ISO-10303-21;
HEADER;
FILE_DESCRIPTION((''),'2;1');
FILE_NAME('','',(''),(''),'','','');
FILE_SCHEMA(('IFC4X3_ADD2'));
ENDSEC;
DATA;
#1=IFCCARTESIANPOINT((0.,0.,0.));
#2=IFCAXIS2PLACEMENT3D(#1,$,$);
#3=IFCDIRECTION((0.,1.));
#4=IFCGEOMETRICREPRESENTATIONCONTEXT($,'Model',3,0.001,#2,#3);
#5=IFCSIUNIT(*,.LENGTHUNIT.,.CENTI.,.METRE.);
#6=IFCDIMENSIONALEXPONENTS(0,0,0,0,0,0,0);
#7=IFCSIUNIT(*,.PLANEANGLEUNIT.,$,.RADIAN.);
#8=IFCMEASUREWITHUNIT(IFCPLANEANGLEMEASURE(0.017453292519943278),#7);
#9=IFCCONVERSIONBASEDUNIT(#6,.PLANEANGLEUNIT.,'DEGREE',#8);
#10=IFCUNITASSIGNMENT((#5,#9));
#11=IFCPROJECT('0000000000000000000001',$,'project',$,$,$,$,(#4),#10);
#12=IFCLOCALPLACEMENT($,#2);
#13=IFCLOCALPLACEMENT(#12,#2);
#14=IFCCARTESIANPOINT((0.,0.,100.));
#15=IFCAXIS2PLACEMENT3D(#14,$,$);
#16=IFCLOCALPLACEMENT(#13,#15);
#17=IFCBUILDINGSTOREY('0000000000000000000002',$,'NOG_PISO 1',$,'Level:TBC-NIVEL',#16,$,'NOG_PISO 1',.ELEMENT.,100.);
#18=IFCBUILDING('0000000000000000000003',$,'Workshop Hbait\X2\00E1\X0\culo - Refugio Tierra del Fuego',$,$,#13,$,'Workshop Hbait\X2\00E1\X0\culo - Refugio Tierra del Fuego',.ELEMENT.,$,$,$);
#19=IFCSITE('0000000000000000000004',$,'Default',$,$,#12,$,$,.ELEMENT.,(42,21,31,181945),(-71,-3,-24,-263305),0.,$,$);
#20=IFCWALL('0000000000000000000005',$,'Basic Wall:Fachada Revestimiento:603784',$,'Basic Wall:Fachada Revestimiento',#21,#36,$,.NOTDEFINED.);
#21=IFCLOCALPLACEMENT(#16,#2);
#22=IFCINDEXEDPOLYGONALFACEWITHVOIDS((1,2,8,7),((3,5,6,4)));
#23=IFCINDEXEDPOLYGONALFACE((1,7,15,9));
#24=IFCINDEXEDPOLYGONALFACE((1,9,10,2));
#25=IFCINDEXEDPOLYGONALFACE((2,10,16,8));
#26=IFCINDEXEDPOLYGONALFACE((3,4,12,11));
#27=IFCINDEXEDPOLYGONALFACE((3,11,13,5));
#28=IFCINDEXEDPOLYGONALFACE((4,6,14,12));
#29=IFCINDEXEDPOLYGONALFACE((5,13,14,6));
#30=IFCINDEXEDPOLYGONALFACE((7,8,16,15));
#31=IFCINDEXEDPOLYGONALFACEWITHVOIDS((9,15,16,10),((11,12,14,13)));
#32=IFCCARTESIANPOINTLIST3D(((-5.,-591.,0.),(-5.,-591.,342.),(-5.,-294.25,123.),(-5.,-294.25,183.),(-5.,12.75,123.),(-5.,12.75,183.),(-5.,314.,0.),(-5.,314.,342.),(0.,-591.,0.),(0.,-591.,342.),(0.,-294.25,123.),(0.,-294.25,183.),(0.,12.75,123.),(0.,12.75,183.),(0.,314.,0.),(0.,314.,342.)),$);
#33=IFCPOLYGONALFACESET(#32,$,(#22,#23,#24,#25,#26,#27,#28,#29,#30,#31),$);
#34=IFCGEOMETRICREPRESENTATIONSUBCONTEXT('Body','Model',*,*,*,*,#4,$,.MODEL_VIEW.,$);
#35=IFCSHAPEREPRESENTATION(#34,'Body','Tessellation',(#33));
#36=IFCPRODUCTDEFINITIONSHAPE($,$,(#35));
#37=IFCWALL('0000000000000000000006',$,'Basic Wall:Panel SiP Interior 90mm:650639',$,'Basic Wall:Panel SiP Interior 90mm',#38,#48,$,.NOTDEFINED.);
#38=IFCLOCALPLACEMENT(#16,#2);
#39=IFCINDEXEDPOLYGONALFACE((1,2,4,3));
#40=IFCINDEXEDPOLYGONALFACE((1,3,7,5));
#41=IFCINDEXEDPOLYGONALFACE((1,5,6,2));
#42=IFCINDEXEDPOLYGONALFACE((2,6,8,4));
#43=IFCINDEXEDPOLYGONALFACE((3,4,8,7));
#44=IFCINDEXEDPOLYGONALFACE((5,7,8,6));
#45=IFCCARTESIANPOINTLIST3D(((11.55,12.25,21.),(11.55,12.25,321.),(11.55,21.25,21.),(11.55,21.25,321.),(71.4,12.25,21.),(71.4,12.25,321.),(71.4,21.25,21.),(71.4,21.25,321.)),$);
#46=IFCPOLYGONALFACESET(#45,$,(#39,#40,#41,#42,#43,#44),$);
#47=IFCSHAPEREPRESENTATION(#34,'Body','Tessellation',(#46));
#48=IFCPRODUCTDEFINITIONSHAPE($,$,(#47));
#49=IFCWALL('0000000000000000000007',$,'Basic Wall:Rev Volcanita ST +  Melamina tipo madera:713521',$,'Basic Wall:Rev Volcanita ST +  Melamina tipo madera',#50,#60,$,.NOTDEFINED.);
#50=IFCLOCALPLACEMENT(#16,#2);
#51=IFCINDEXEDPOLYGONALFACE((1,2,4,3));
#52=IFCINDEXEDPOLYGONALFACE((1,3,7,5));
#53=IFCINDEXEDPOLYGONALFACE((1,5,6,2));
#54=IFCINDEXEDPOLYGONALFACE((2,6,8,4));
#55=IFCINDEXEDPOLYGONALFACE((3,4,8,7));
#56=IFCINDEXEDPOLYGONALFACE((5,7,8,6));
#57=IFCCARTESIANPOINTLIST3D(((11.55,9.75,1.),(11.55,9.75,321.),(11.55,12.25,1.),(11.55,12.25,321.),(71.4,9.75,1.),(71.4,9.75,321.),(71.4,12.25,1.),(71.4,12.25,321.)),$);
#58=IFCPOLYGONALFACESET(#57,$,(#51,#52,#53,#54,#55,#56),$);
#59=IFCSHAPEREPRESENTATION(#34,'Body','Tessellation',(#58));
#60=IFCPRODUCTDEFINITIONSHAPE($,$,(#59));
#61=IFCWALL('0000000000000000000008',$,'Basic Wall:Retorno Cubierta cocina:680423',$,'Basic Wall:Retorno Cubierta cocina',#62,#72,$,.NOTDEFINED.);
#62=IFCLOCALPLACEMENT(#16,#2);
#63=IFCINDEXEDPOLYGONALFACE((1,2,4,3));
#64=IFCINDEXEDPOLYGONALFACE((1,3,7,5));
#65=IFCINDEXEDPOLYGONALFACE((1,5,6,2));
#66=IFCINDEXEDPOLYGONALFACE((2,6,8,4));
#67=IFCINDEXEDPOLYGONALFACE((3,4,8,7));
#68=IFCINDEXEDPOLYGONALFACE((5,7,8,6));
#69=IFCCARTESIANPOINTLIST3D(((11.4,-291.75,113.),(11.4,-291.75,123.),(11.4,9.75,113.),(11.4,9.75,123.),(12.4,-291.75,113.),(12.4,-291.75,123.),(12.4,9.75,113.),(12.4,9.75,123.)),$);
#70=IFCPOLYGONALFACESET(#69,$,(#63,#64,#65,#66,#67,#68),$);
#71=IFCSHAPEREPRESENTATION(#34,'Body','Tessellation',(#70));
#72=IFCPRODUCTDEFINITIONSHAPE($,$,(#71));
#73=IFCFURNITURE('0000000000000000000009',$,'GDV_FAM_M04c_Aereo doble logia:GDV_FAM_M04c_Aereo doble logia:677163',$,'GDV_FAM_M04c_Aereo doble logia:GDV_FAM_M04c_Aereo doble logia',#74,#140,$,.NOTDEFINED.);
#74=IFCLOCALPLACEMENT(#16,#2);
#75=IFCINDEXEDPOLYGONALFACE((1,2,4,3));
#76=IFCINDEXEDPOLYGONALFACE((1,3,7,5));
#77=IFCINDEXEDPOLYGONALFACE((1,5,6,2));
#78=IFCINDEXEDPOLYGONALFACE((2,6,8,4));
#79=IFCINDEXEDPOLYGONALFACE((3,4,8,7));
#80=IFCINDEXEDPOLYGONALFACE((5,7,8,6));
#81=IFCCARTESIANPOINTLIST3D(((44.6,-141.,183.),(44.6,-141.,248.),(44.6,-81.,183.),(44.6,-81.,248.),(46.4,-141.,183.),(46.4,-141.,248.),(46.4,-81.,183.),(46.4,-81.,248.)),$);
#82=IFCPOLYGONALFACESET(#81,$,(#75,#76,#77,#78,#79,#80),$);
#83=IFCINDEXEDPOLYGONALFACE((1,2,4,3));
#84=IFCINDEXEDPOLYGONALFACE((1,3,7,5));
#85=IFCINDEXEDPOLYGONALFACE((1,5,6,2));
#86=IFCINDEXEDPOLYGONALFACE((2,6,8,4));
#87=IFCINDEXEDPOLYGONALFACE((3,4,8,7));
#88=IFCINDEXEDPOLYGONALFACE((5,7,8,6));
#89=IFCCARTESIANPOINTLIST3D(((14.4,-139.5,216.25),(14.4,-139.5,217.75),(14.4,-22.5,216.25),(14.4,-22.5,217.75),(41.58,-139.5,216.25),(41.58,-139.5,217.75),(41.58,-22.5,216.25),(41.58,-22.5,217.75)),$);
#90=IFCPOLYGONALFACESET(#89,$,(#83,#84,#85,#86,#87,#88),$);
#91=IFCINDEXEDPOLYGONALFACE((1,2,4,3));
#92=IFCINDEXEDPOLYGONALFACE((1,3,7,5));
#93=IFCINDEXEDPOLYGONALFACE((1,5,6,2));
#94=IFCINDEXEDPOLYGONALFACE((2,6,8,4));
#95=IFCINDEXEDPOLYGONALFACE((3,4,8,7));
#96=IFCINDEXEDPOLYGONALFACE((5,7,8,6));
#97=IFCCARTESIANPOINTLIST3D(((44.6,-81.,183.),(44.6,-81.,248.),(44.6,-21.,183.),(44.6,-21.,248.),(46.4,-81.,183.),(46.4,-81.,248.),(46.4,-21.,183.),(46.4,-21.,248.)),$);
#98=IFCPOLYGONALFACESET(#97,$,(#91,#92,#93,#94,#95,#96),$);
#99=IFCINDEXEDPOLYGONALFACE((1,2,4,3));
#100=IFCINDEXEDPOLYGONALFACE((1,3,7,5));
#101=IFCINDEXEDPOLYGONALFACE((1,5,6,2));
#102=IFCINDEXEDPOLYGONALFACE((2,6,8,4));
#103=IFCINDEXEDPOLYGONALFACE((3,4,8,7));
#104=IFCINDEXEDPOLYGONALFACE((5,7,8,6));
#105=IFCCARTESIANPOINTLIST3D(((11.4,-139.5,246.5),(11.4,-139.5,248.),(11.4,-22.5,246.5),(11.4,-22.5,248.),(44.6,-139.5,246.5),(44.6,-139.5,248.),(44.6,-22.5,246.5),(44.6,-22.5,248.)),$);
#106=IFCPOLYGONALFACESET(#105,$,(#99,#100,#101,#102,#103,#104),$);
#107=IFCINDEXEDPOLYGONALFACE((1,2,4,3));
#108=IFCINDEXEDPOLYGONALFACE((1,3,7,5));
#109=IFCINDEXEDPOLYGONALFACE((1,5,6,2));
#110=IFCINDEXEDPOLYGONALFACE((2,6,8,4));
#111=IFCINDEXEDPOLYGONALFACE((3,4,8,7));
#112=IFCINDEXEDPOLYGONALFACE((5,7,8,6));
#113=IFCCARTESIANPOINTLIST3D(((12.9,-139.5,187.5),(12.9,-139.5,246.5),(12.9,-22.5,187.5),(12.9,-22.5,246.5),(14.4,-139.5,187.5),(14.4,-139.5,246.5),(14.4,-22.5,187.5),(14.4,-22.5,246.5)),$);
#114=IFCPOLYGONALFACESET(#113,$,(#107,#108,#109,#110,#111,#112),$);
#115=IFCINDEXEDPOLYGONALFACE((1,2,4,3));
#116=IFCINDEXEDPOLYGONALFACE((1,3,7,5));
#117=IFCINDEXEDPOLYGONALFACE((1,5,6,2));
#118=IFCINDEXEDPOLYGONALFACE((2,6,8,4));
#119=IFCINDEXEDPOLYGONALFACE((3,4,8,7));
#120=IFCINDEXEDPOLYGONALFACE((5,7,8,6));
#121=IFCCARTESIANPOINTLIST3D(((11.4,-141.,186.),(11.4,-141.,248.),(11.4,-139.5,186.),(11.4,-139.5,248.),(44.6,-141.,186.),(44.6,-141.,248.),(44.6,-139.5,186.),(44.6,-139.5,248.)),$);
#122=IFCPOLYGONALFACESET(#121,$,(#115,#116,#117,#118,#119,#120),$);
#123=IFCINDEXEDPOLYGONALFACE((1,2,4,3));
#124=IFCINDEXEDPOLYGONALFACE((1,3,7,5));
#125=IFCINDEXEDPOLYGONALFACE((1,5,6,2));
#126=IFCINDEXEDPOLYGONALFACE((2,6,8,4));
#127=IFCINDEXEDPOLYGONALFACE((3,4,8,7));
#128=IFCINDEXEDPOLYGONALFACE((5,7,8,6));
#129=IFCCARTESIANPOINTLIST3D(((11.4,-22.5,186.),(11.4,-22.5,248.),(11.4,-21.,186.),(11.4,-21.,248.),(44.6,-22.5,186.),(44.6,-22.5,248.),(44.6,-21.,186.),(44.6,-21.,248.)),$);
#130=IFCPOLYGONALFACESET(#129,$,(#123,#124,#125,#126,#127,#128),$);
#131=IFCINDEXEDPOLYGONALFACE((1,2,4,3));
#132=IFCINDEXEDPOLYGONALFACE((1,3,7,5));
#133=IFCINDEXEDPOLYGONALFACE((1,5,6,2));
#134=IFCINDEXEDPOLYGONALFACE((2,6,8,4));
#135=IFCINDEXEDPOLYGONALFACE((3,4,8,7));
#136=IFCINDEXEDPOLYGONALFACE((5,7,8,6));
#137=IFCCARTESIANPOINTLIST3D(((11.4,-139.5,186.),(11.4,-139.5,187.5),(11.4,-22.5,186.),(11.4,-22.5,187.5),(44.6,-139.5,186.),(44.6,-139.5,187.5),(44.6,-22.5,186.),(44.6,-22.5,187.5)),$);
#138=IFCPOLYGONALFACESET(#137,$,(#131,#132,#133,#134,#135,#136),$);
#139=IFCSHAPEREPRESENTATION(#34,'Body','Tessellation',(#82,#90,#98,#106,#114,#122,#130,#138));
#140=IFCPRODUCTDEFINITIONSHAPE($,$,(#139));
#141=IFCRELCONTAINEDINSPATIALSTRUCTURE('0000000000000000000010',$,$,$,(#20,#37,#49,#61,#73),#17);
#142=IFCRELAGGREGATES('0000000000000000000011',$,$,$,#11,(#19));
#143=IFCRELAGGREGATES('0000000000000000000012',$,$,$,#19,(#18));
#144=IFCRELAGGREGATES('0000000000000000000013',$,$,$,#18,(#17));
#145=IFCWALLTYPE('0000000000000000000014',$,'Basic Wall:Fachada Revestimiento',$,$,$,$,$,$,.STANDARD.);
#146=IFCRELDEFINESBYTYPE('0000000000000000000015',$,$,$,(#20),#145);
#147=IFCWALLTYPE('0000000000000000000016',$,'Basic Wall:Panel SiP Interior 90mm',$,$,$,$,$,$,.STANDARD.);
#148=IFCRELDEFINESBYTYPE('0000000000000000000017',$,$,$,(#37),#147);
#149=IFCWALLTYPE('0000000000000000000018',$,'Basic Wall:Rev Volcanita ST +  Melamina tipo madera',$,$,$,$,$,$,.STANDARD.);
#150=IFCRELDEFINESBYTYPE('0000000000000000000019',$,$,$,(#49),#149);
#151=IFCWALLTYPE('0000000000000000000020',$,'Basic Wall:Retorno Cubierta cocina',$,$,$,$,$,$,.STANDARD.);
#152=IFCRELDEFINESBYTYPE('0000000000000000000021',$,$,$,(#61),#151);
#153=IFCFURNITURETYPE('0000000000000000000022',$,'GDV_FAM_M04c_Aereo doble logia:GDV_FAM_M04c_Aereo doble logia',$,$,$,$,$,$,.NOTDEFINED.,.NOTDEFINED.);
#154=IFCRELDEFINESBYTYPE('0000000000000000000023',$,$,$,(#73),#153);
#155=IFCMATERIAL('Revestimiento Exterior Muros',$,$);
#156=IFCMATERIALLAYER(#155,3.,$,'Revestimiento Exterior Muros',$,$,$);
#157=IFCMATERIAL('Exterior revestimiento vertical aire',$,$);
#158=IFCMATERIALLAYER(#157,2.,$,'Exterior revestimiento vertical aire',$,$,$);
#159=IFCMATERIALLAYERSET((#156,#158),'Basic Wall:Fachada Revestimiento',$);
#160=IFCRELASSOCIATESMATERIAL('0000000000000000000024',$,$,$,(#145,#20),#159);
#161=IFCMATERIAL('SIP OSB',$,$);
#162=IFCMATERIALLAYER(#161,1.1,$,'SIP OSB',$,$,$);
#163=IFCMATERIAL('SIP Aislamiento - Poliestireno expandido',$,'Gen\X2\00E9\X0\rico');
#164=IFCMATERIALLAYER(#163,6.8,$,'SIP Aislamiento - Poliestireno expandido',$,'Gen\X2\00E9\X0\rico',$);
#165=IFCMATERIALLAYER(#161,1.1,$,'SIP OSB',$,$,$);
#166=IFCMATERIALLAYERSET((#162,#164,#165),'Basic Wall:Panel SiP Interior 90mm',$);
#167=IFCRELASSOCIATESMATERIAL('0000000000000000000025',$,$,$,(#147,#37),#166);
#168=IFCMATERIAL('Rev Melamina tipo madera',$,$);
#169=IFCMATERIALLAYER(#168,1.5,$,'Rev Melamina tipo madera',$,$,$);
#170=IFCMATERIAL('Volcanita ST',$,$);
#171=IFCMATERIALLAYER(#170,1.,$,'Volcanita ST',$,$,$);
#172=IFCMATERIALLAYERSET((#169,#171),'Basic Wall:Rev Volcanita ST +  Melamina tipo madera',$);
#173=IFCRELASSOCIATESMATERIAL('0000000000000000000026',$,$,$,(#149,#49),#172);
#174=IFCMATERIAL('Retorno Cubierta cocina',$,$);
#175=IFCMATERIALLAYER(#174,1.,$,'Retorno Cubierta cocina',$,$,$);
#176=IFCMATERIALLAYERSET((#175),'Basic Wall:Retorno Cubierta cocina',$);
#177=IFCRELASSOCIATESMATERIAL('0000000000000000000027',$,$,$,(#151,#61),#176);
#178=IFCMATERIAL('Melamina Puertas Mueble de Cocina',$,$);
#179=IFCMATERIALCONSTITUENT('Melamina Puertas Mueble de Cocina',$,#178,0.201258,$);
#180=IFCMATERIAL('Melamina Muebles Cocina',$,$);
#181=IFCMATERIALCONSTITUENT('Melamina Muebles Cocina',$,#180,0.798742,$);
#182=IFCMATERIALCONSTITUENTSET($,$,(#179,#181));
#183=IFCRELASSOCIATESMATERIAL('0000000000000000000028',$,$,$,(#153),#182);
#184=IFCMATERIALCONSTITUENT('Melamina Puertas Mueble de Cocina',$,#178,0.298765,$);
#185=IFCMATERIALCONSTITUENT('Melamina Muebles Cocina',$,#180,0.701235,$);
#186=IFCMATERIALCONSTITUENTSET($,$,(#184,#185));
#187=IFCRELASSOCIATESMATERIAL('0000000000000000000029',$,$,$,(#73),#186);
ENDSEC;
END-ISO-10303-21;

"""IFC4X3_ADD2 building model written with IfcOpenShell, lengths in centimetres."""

from ifc_helpers import new_model, entity, si_unit, converted_unit, direction, frame, frame_2d, origin, origin_2d_with_axis, place, context, subcontext, project, spatial, rectangle, extrude, source, transform, mapped, material, layer, layer_set, constituent, constituent_set, type_object, type_shapes, element, save


model = new_model("IFC4X3_ADD2")

# Units and contexts
model_context = context("Model", 3, precision=0.001, world=origin(), true_north=direction((0.0, 1.0)))
body_context = subcontext(model_context, "Body", "Model", "MODEL_VIEW")
ifc_project = project(units=[si_unit("LENGTHUNIT", "METRE", prefix="CENTI"), converted_unit("PLANEANGLEUNIT", "DEGREE", entity("IfcPlaneAngleMeasure", 0.017453292519943278), si_unit("PLANEANGLEUNIT", "RADIAN"), dimensions=[0, 0, 0, 0, 0, 0, 0])], contexts=[model_context])

# Site, building, storey
site_placement = place(None, origin())
site = spatial("IfcSite", under=ifc_project, at=site_placement, Name="Default", CompositionType="ELEMENT", RefLatitude=(42, 21, 31, 181945), RefLongitude=(-71, -3, -24, -263305), RefElevation=0.0)
building_placement = place(site_placement, origin())
building = spatial("IfcBuilding", under=site, at=building_placement, Name="Workshop Hbaitáculo - Refugio Tierra del Fuego", LongName="Workshop Hbaitáculo - Refugio Tierra del Fuego", CompositionType="ELEMENT")
storey_placement = place(building_placement, frame((0.0, 0.0, 100.0)))
storey = spatial("IfcBuildingStorey", under=building, at=storey_placement, Name="NOG_PISO 1", ObjectType="Level:TBC-NIVEL", LongName="NOG_PISO 1", CompositionType="ELEMENT", Elevation=100.0)

# Shared definitions
ifc_material_1 = material(Name="SIP OSB")
ifc_material_2 = material(Name="SIP Aislamiento - Poliestireno expandido", Category="Genérico")

# Wall, opening
ifc_material_3 = material(Name="Revestimiento Exterior Muros")
ifc_layer_1 = layer(ifc_material_3, 3.0, Name="Revestimiento Exterior Muros")
ifc_material_4 = material(Name="Exterior revestimiento vertical aire")
ifc_layer_2 = layer(ifc_material_4, 2.0, Name="Exterior revestimiento vertical aire")
ifc_layer_set_1 = layer_set([ifc_layer_1, ifc_layer_2], Name="Basic Wall:Fachada Revestimiento")
wall_type_1 = type_object("IfcWallType", Name="Basic Wall:Fachada Revestimiento", PredefinedType="STANDARD", material=ifc_layer_set_1)
wall_1_placement = place(storey_placement, frame((-2.5, 314.0, 0.0), z_axis=(0.0, 0.0, 1.0), x_axis=(0.0, -1.0, 0.0)))
wall_1 = element("IfcWall", 1, at=wall_1_placement, inside=storey, type_object=wall_type_1, material=ifc_layer_set_1, Name="Basic Wall:Fachada Revestimiento:603784", ObjectType="Basic Wall:Fachada Revestimiento", PredefinedType="NOTDEFINED", context=body_context, shape_type="SweptSolid", body=[
    extrude(rectangle(XDim=905.0, YDim=5.0, at=frame_2d((452.5, 0.0), x_axis=(-1.0, 0.0))), origin(), (0.0, 0.0, 1.0), 342.0),
])
opening_1_placement = place(wall_1_placement, origin())
element("IfcOpeningElement", 2, at=opening_1_placement, cuts=wall_1, PredefinedType="OPENING", context=body_context, shape_type="SweptSolid", body=[
    extrude(rectangle(XDim=60.0, YDim=307.0, at=frame_2d((0.0, 0.0), x_axis=(0.0, 1.0))), frame((454.75, 2.5, 153.0), z_axis=(0.0, -1.0, 0.0), x_axis=(1.0, 0.0, 0.0)), (0.0, 0.0, 1.0), 5.0),
])

# Walls
ifc_layer_3 = layer(ifc_material_1, 1.1, Name="SIP OSB")
ifc_layer_4 = layer(ifc_material_2, 6.8, Name="SIP Aislamiento - Poliestireno expandido", Category="Genérico")
ifc_layer_5 = layer(ifc_material_1, 1.1, Name="SIP OSB")
ifc_layer_set_2 = layer_set([ifc_layer_3, ifc_layer_4, ifc_layer_5], Name="Basic Wall:Panel SiP Interior 90mm")
wall_type_2 = type_object("IfcWallType", Name="Basic Wall:Panel SiP Interior 90mm", PredefinedType="STANDARD", material=ifc_layer_set_2)
wall_2_placement = place(storey_placement, frame((71.4, 16.75, 21.0), z_axis=(0.0, 0.0, 1.0), x_axis=(-1.0, 0.0, 0.0)))
element("IfcWall", 3, at=wall_2_placement, inside=storey, type_object=wall_type_2, material=ifc_layer_set_2, Name="Basic Wall:Panel SiP Interior 90mm:650639", ObjectType="Basic Wall:Panel SiP Interior 90mm", PredefinedType="NOTDEFINED", context=body_context, shape_type="SweptSolid", body=[
    extrude(rectangle(XDim=59.85, YDim=9.0, at=frame_2d((29.93, 0.0), x_axis=(-1.0, 0.0))), origin(), (0.0, 0.0, 1.0), 300.0),
])
ifc_material_5 = material(Name="Rev Melamina tipo madera")
ifc_layer_6 = layer(ifc_material_5, 1.5, Name="Rev Melamina tipo madera")
ifc_material_6 = material(Name="Volcanita ST")
ifc_layer_7 = layer(ifc_material_6, 1.0, Name="Volcanita ST")
ifc_layer_set_3 = layer_set([ifc_layer_6, ifc_layer_7], Name="Basic Wall:Rev Volcanita ST +  Melamina tipo madera")
wall_type_3 = type_object("IfcWallType", Name="Basic Wall:Rev Volcanita ST +  Melamina tipo madera", PredefinedType="STANDARD", material=ifc_layer_set_3)
wall_3_placement = place(storey_placement, frame((11.55, 11.0, 1.0)))
element("IfcWall", 4, at=wall_3_placement, inside=storey, type_object=wall_type_3, material=ifc_layer_set_3, Name="Basic Wall:Rev Volcanita ST +  Melamina tipo madera:713521", ObjectType="Basic Wall:Rev Volcanita ST +  Melamina tipo madera", PredefinedType="NOTDEFINED", context=body_context, shape_type="SweptSolid", body=[
    extrude(rectangle(XDim=59.85, YDim=2.5, at=frame_2d((29.93, 0.0), x_axis=(-1.0, 0.0))), origin(), (0.0, 0.0, 1.0), 320.0),
])
ifc_material_7 = material(Name="Retorno Cubierta cocina")
ifc_layer_8 = layer(ifc_material_7, 1.0, Name="Retorno Cubierta cocina")
ifc_layer_set_4 = layer_set([ifc_layer_8], Name="Basic Wall:Retorno Cubierta cocina")
wall_type_4 = type_object("IfcWallType", Name="Basic Wall:Retorno Cubierta cocina", PredefinedType="STANDARD", material=ifc_layer_set_4)
wall_4_placement = place(storey_placement, frame((11.9, 9.75, 113.0), z_axis=(0.0, 0.0, 1.0), x_axis=(0.0, -1.0, 0.0)))
element("IfcWall", 5, at=wall_4_placement, inside=storey, type_object=wall_type_4, material=ifc_layer_set_4, Name="Basic Wall:Retorno Cubierta cocina:680423", ObjectType="Basic Wall:Retorno Cubierta cocina", PredefinedType="NOTDEFINED", context=body_context, shape_type="SweptSolid", body=[
    extrude(rectangle(XDim=301.5, YDim=1.0, at=frame_2d((150.75, 0.0), x_axis=(-1.0, 0.0))), origin(), (0.0, 0.0, 1.0), 10.0),
])

# Furniture
ifc_material_8 = material(Name="Melamina Puertas Mueble de Cocina")
ifc_constituent_1 = constituent(ifc_material_8, Name="Melamina Puertas Mueble de Cocina", fraction=0.298765)
ifc_material_9 = material(Name="Melamina Muebles Cocina")
ifc_constituent_2 = constituent(ifc_material_9, Name="Melamina Muebles Cocina", fraction=0.701235)
ifc_constituent_set_1 = constituent_set(constituents=[ifc_constituent_1, ifc_constituent_2])
ifc_constituent_3 = constituent(ifc_material_8, Name="Melamina Puertas Mueble de Cocina", fraction=0.201258)
ifc_constituent_4 = constituent(ifc_material_9, Name="Melamina Muebles Cocina", fraction=0.798742)
ifc_constituent_set_2 = constituent_set(constituents=[ifc_constituent_3, ifc_constituent_4])
furniture_type_1 = type_object("IfcFurnitureType", Name="GDV_FAM_M04c_Aereo doble logia:GDV_FAM_M04c_Aereo doble logia", AssemblyPlace="NOTDEFINED", PredefinedType="NOTDEFINED", material=ifc_constituent_set_2)
shared_shape_1 = source(origin(), body_context, "Body", "SweptSolid", [
    extrude(rectangle(XDim=1.8, YDim=60.0, at=frame_2d((0.0, 0.0), x_axis=(1.0, 0.0))), frame((90.0, 34.1, 0.0), z_axis=(0.0, 0.0, 1.0), x_axis=(0.0, 1.0, 0.0)), (0.0, 0.0, 1.0), 65.0),
    extrude(rectangle(XDim=27.18, YDim=117.0, at=frame_2d((0.0, 0.0), x_axis=(1.0, 0.0))), frame((60.0, 16.59, 33.25), z_axis=(0.0, 0.0, 1.0), x_axis=(0.0, 1.0, 0.0)), (0.0, 0.0, 1.0), 1.5),
    extrude(rectangle(XDim=1.8, YDim=60.0, at=frame_2d((0.0, 0.0), x_axis=(1.0, 0.0))), frame((30.0, 34.1, 0.0), z_axis=(0.0, 0.0, 1.0), x_axis=(0.0, 1.0, 0.0)), (0.0, 0.0, 1.0), 65.0),
    extrude(rectangle(XDim=33.2, YDim=117.0, at=frame_2d((0.0, 0.0), x_axis=(1.0, 0.0))), frame((60.0, 16.6, 63.5), z_axis=(0.0, 0.0, 1.0), x_axis=(0.0, 1.0, 0.0)), (0.0, 0.0, 1.0), 1.5),
    extrude(rectangle(XDim=1.5, YDim=117.0, at=frame_2d((0.0, 0.0), x_axis=(1.0, 0.0))), frame((60.0, 2.25, 4.5), z_axis=(0.0, 0.0, 1.0), x_axis=(0.0, 1.0, 0.0)), (0.0, 0.0, 1.0), 59.0),
    extrude(rectangle(XDim=1.5, YDim=33.2, at=frame_2d((0.0, 0.0), x_axis=(1.0, 0.0))), frame((119.25, 16.6, 3.0), z_axis=(0.0, 0.0, 1.0), x_axis=(-1.0, 0.0, 0.0)), (0.0, 0.0, 1.0), 62.0),
    extrude(rectangle(XDim=1.5, YDim=33.2, at=origin_2d_with_axis()), frame((0.75, 16.6, 3.0), z_axis=(0.0, 0.0, 1.0), x_axis=(-1.0, 0.0, 0.0)), (0.0, 0.0, 1.0), 62.0),
    extrude(rectangle(XDim=33.2, YDim=117.0, at=frame_2d((0.0, 0.0), x_axis=(1.0, 0.0))), frame((60.0, 16.6, 3.0), z_axis=(0.0, 0.0, 1.0), x_axis=(0.0, 1.0, 0.0)), (0.0, 0.0, 1.0), 1.5),
])
type_shapes(furniture_type_1, [shared_shape_1])
furniture_1_placement = place(storey_placement, frame((11.4, -21.0, 183.0), z_axis=(0.0, 0.0, 1.0), x_axis=(0.0, -1.0, 0.0)))
element("IfcFurniture", 6, at=furniture_1_placement, inside=storey, type_object=furniture_type_1, material=ifc_constituent_set_1, Name="GDV_FAM_M04c_Aereo doble logia:GDV_FAM_M04c_Aereo doble logia:677163", ObjectType="GDV_FAM_M04c_Aereo doble logia:GDV_FAM_M04c_Aereo doble logia", PredefinedType="NOTDEFINED", context=body_context, shape_type="MappedRepresentation", body=[
    mapped(shared_shape_1, transform((0.0, 0.0, 0.0), scale=1.0)),
])

save(model, "model.ifc")
